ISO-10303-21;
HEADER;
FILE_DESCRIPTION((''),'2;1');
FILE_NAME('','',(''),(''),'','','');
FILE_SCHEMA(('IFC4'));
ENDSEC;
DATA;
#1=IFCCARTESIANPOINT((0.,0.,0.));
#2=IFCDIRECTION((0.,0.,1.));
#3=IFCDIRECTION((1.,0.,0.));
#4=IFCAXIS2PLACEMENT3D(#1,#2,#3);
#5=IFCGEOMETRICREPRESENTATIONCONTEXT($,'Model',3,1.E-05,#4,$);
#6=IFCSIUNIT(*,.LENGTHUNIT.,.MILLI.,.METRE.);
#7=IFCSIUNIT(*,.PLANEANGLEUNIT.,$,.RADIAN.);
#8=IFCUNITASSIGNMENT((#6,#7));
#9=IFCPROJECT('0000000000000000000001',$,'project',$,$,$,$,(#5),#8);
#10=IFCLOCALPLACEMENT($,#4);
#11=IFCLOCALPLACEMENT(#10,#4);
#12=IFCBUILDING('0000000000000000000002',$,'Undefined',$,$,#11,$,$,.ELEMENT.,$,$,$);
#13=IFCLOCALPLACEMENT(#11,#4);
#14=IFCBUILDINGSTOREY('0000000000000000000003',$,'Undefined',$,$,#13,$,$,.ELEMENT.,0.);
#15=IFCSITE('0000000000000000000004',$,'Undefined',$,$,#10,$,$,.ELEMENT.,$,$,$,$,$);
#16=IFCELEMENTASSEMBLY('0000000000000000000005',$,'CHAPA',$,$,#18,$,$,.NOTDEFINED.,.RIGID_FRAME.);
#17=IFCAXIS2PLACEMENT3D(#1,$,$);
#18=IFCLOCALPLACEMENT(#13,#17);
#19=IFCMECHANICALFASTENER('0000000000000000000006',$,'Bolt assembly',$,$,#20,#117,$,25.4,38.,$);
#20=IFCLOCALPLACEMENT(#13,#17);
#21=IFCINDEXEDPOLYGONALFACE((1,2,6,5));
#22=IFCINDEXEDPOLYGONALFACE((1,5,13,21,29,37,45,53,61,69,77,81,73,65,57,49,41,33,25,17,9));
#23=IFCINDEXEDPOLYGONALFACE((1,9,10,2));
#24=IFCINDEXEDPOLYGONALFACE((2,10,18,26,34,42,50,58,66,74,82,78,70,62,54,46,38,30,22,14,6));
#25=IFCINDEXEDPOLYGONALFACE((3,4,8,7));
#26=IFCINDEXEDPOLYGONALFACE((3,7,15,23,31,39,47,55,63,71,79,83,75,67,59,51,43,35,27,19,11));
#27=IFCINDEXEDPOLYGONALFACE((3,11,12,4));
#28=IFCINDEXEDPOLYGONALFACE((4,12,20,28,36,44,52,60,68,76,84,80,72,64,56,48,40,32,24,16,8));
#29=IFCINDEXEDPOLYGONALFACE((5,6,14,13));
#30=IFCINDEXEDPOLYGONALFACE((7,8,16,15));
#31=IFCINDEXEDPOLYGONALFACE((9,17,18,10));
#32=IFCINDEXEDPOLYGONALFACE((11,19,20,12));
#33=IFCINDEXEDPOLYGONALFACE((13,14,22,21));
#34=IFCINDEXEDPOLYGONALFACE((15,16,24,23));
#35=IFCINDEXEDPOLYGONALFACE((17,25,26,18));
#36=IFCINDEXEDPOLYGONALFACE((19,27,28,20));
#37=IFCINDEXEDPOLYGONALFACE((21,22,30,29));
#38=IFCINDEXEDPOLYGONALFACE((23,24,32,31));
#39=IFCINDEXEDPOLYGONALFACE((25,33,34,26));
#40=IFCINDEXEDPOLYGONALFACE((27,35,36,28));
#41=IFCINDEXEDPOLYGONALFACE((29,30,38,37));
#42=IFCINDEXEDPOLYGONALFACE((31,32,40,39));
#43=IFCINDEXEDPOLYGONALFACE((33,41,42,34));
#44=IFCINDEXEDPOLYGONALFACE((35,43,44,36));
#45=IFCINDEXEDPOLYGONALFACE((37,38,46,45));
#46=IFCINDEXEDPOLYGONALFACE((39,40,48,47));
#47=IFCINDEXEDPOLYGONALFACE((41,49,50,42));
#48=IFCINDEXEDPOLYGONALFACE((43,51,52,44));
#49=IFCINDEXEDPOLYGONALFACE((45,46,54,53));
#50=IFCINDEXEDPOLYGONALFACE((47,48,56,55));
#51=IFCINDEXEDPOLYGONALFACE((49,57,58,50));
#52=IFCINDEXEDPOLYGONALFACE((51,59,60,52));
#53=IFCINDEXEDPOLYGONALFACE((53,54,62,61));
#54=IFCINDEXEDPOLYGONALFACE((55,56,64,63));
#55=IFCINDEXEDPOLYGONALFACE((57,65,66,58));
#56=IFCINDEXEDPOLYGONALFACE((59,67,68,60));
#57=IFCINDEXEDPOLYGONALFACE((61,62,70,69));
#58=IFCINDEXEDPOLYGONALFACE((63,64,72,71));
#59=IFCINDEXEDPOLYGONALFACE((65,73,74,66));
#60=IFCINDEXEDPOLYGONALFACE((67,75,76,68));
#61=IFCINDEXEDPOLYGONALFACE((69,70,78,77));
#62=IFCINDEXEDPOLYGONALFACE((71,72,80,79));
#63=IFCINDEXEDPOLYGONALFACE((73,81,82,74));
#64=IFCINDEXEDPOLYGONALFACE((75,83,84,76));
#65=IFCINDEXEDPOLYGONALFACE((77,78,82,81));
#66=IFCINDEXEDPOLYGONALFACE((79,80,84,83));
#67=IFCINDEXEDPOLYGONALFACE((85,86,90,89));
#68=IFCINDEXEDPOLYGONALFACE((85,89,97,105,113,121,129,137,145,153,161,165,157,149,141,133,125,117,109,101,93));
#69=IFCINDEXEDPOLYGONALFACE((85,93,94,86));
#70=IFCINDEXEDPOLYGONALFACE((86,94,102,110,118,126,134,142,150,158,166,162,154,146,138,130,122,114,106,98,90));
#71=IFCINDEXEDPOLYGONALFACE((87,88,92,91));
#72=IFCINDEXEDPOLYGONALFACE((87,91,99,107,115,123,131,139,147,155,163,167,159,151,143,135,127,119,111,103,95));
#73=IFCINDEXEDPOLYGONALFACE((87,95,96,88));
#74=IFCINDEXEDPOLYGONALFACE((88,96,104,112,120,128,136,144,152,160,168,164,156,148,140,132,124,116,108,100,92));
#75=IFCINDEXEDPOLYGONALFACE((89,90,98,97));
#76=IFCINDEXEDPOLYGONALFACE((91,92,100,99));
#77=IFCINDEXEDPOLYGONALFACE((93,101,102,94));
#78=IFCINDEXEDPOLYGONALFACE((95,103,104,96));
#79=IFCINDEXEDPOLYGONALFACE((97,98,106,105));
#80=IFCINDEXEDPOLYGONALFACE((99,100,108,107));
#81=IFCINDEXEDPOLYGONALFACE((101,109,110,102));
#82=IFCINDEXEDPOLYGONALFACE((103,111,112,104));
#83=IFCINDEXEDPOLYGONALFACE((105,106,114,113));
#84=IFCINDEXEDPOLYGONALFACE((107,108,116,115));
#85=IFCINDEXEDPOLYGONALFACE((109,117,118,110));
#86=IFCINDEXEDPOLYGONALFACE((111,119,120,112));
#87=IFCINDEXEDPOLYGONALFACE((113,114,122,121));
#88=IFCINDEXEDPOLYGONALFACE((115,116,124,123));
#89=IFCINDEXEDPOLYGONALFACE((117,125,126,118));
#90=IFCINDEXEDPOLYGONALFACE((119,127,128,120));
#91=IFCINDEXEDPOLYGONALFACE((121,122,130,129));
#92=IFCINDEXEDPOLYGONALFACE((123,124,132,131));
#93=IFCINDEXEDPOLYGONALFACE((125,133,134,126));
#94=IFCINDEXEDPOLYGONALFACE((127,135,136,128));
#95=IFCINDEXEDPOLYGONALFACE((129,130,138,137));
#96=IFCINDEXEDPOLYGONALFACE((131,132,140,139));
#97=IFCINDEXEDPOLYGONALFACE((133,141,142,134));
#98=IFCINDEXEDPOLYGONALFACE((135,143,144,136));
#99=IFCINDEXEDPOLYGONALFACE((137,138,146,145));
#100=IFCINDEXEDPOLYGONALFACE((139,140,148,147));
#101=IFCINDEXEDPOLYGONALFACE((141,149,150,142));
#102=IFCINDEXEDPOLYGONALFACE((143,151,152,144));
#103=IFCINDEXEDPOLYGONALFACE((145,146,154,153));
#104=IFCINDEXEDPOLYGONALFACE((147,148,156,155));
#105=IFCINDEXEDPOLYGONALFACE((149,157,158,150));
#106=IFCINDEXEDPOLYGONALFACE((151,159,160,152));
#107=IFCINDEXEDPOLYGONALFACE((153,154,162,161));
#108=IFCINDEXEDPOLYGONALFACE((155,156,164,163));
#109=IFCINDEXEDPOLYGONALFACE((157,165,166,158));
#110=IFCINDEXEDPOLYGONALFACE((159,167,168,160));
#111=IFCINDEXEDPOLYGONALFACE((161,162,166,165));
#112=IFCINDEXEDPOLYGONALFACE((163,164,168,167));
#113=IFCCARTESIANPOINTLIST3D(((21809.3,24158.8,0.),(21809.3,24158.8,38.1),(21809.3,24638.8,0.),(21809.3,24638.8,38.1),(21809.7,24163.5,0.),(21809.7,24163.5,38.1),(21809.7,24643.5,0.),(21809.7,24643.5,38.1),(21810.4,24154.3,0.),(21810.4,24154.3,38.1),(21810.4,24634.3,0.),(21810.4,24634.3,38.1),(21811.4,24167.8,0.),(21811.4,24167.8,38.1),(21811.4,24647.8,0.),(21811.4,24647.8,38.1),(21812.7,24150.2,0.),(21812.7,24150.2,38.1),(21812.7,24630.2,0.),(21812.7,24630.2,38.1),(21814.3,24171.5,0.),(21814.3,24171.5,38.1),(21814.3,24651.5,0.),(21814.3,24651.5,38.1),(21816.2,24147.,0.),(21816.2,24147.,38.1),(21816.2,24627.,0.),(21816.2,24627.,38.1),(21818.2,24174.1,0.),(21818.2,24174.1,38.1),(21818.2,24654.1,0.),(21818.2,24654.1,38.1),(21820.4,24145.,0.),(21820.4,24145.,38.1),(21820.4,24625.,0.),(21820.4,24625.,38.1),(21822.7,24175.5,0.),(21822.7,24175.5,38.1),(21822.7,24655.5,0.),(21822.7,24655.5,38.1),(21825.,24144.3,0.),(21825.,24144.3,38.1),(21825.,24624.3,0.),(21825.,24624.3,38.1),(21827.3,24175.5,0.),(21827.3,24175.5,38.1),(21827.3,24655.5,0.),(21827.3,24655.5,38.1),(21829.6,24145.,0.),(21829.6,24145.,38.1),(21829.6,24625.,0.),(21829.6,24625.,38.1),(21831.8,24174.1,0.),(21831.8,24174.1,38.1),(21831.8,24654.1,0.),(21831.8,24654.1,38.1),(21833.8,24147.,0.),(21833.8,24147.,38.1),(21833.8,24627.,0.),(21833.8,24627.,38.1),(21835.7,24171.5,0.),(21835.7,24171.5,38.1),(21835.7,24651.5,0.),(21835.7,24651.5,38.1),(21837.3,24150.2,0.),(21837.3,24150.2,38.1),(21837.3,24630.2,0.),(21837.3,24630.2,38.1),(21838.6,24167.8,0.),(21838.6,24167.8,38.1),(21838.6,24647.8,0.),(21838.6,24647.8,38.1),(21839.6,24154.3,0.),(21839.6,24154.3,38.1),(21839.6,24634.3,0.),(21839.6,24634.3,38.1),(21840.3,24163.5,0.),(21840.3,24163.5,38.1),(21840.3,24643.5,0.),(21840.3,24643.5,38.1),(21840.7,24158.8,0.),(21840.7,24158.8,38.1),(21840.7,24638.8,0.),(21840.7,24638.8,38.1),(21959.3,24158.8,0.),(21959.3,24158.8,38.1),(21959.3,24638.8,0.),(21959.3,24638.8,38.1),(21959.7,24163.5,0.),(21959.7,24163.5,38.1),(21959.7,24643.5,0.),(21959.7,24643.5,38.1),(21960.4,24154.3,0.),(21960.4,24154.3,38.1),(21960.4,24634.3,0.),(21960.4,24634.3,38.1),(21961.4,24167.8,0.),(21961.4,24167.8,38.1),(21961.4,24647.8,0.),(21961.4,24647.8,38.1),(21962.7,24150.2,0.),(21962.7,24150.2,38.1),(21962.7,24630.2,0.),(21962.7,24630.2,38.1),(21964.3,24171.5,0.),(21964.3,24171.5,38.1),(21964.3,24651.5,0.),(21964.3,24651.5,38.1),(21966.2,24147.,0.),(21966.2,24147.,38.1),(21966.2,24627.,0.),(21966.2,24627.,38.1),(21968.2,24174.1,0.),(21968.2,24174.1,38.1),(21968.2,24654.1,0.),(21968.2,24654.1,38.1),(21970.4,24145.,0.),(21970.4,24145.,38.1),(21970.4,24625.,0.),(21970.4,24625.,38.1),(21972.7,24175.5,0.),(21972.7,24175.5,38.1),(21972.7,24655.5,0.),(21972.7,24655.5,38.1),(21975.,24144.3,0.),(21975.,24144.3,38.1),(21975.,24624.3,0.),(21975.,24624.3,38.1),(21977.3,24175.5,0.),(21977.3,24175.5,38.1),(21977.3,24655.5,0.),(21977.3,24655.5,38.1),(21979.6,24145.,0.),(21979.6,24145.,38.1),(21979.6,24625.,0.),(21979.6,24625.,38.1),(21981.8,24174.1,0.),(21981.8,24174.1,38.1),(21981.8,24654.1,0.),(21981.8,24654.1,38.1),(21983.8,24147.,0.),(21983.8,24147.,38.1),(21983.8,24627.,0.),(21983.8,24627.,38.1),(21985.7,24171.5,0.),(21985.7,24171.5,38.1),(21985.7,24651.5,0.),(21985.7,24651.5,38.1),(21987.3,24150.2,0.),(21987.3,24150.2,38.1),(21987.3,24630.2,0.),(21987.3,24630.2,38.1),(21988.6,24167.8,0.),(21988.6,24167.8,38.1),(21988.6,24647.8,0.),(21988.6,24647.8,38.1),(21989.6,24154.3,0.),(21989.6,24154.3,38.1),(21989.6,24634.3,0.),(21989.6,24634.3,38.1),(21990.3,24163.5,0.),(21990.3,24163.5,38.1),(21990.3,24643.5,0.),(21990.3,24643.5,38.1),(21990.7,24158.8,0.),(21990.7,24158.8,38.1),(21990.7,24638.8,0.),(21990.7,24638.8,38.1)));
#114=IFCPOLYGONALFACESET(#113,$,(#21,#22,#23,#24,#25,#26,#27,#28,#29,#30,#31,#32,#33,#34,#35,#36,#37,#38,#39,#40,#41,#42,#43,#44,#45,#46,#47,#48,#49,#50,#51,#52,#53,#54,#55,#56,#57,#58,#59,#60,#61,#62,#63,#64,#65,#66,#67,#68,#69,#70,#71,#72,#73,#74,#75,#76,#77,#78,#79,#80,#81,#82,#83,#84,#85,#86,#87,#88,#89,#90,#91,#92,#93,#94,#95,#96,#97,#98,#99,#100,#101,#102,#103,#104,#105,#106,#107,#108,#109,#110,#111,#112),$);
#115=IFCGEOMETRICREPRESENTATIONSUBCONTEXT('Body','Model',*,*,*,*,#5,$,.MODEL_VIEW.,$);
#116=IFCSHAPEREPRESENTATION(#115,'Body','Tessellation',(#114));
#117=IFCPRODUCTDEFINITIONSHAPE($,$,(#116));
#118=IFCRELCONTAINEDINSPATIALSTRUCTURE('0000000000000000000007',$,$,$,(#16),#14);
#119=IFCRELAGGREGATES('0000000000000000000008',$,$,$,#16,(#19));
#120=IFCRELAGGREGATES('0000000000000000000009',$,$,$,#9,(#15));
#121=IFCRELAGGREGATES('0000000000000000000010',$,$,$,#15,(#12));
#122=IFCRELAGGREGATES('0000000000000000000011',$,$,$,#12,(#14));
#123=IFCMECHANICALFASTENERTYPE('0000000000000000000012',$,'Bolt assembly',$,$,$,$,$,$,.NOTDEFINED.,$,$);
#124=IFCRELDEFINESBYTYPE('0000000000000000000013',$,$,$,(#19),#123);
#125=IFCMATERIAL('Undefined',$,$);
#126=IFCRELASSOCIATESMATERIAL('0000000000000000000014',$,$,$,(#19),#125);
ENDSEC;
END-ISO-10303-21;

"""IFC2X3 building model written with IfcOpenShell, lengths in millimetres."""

from ifc_helpers import new_model, si_unit, frame, origin_with_axes, origin_2d_with_axis, place, context, subcontext, project, spatial, circle, extrude, source, transform, mapped, material, type_object, element, aggregate, save


model = new_model("IFC2X3")

# Units and contexts
model_context = context("Model", 3, precision=1e-05, world=origin_with_axes())
body_context = subcontext(model_context, "Body", "Model", "MODEL_VIEW")
ifc_project = project(units=[si_unit("LENGTHUNIT", "METRE", prefix="MILLI"), si_unit("PLANEANGLEUNIT", "RADIAN")], contexts=[model_context])

# Site, building, storey
site_placement = place(None, origin_with_axes())
site = spatial("IfcSite", under=ifc_project, at=site_placement, Name="Undefined", CompositionType="ELEMENT")
building_placement = place(site_placement, origin_with_axes())
building = spatial("IfcBuilding", under=site, at=building_placement, Name="Undefined", CompositionType="ELEMENT")
storey_placement = place(building_placement, origin_with_axes())
storey = spatial("IfcBuildingStorey", under=building, at=storey_placement, Name="Undefined", CompositionType="ELEMENT", Elevation=0.0)

# Element assembly
assembly_1_placement = place(storey_placement, origin_with_axes())
assembly_1 = element("IfcElementAssembly", 1, at=assembly_1_placement, inside=storey, Name="CHAPA", AssemblyPlace="NOTDEFINED", PredefinedType="RIGID_FRAME")

# Shared definitions
ifc_material_1 = material(Name="Undefined")
mechanical_fastener_type = type_object("IfcMechanicalFastenerType", Name="Bolt assembly")

# Mechanical fastener
shared_shape_1 = source(origin_with_axes(), body_context, "Body", "SweptSolid", [
    extrude(circle(Radius=15.7, at=origin_2d_with_axis()), frame((0.0, -38.0, 0.0), z_axis=(0.0, 1.0, 0.0), x_axis=(1.0, 0.0, 0.0)), (0.0, 0.0, 1.0), 38.1),
])
mechanical_fastener_1_placement = place(assembly_1_placement, frame((21900.0, 24640.0, 38.0), z_axis=(-1.0, 0.0, 0.0), x_axis=(0.0, -1.0, 0.0)))
mechanical_fastener_1 = element("IfcMechanicalFastener", 2, at=mechanical_fastener_1_placement, type_object=mechanical_fastener_type, material=ifc_material_1, Name="Bolt assembly", NominalDiameter=25.4, NominalLength=38.0, context=body_context, shape_type="MappedRepresentation", body=[
    mapped(shared_shape_1, transform((0.0, 0.0, -75.0))),
    mapped(shared_shape_1, transform((0.0, 0.0, 75.0))),
    mapped(shared_shape_1, transform((480.0, 0.0, -75.0))),
    mapped(shared_shape_1, transform((480.0, 0.0, 75.0))),
])
aggregate(assembly_1, [mechanical_fastener_1])

save(model, "model.ifc")
